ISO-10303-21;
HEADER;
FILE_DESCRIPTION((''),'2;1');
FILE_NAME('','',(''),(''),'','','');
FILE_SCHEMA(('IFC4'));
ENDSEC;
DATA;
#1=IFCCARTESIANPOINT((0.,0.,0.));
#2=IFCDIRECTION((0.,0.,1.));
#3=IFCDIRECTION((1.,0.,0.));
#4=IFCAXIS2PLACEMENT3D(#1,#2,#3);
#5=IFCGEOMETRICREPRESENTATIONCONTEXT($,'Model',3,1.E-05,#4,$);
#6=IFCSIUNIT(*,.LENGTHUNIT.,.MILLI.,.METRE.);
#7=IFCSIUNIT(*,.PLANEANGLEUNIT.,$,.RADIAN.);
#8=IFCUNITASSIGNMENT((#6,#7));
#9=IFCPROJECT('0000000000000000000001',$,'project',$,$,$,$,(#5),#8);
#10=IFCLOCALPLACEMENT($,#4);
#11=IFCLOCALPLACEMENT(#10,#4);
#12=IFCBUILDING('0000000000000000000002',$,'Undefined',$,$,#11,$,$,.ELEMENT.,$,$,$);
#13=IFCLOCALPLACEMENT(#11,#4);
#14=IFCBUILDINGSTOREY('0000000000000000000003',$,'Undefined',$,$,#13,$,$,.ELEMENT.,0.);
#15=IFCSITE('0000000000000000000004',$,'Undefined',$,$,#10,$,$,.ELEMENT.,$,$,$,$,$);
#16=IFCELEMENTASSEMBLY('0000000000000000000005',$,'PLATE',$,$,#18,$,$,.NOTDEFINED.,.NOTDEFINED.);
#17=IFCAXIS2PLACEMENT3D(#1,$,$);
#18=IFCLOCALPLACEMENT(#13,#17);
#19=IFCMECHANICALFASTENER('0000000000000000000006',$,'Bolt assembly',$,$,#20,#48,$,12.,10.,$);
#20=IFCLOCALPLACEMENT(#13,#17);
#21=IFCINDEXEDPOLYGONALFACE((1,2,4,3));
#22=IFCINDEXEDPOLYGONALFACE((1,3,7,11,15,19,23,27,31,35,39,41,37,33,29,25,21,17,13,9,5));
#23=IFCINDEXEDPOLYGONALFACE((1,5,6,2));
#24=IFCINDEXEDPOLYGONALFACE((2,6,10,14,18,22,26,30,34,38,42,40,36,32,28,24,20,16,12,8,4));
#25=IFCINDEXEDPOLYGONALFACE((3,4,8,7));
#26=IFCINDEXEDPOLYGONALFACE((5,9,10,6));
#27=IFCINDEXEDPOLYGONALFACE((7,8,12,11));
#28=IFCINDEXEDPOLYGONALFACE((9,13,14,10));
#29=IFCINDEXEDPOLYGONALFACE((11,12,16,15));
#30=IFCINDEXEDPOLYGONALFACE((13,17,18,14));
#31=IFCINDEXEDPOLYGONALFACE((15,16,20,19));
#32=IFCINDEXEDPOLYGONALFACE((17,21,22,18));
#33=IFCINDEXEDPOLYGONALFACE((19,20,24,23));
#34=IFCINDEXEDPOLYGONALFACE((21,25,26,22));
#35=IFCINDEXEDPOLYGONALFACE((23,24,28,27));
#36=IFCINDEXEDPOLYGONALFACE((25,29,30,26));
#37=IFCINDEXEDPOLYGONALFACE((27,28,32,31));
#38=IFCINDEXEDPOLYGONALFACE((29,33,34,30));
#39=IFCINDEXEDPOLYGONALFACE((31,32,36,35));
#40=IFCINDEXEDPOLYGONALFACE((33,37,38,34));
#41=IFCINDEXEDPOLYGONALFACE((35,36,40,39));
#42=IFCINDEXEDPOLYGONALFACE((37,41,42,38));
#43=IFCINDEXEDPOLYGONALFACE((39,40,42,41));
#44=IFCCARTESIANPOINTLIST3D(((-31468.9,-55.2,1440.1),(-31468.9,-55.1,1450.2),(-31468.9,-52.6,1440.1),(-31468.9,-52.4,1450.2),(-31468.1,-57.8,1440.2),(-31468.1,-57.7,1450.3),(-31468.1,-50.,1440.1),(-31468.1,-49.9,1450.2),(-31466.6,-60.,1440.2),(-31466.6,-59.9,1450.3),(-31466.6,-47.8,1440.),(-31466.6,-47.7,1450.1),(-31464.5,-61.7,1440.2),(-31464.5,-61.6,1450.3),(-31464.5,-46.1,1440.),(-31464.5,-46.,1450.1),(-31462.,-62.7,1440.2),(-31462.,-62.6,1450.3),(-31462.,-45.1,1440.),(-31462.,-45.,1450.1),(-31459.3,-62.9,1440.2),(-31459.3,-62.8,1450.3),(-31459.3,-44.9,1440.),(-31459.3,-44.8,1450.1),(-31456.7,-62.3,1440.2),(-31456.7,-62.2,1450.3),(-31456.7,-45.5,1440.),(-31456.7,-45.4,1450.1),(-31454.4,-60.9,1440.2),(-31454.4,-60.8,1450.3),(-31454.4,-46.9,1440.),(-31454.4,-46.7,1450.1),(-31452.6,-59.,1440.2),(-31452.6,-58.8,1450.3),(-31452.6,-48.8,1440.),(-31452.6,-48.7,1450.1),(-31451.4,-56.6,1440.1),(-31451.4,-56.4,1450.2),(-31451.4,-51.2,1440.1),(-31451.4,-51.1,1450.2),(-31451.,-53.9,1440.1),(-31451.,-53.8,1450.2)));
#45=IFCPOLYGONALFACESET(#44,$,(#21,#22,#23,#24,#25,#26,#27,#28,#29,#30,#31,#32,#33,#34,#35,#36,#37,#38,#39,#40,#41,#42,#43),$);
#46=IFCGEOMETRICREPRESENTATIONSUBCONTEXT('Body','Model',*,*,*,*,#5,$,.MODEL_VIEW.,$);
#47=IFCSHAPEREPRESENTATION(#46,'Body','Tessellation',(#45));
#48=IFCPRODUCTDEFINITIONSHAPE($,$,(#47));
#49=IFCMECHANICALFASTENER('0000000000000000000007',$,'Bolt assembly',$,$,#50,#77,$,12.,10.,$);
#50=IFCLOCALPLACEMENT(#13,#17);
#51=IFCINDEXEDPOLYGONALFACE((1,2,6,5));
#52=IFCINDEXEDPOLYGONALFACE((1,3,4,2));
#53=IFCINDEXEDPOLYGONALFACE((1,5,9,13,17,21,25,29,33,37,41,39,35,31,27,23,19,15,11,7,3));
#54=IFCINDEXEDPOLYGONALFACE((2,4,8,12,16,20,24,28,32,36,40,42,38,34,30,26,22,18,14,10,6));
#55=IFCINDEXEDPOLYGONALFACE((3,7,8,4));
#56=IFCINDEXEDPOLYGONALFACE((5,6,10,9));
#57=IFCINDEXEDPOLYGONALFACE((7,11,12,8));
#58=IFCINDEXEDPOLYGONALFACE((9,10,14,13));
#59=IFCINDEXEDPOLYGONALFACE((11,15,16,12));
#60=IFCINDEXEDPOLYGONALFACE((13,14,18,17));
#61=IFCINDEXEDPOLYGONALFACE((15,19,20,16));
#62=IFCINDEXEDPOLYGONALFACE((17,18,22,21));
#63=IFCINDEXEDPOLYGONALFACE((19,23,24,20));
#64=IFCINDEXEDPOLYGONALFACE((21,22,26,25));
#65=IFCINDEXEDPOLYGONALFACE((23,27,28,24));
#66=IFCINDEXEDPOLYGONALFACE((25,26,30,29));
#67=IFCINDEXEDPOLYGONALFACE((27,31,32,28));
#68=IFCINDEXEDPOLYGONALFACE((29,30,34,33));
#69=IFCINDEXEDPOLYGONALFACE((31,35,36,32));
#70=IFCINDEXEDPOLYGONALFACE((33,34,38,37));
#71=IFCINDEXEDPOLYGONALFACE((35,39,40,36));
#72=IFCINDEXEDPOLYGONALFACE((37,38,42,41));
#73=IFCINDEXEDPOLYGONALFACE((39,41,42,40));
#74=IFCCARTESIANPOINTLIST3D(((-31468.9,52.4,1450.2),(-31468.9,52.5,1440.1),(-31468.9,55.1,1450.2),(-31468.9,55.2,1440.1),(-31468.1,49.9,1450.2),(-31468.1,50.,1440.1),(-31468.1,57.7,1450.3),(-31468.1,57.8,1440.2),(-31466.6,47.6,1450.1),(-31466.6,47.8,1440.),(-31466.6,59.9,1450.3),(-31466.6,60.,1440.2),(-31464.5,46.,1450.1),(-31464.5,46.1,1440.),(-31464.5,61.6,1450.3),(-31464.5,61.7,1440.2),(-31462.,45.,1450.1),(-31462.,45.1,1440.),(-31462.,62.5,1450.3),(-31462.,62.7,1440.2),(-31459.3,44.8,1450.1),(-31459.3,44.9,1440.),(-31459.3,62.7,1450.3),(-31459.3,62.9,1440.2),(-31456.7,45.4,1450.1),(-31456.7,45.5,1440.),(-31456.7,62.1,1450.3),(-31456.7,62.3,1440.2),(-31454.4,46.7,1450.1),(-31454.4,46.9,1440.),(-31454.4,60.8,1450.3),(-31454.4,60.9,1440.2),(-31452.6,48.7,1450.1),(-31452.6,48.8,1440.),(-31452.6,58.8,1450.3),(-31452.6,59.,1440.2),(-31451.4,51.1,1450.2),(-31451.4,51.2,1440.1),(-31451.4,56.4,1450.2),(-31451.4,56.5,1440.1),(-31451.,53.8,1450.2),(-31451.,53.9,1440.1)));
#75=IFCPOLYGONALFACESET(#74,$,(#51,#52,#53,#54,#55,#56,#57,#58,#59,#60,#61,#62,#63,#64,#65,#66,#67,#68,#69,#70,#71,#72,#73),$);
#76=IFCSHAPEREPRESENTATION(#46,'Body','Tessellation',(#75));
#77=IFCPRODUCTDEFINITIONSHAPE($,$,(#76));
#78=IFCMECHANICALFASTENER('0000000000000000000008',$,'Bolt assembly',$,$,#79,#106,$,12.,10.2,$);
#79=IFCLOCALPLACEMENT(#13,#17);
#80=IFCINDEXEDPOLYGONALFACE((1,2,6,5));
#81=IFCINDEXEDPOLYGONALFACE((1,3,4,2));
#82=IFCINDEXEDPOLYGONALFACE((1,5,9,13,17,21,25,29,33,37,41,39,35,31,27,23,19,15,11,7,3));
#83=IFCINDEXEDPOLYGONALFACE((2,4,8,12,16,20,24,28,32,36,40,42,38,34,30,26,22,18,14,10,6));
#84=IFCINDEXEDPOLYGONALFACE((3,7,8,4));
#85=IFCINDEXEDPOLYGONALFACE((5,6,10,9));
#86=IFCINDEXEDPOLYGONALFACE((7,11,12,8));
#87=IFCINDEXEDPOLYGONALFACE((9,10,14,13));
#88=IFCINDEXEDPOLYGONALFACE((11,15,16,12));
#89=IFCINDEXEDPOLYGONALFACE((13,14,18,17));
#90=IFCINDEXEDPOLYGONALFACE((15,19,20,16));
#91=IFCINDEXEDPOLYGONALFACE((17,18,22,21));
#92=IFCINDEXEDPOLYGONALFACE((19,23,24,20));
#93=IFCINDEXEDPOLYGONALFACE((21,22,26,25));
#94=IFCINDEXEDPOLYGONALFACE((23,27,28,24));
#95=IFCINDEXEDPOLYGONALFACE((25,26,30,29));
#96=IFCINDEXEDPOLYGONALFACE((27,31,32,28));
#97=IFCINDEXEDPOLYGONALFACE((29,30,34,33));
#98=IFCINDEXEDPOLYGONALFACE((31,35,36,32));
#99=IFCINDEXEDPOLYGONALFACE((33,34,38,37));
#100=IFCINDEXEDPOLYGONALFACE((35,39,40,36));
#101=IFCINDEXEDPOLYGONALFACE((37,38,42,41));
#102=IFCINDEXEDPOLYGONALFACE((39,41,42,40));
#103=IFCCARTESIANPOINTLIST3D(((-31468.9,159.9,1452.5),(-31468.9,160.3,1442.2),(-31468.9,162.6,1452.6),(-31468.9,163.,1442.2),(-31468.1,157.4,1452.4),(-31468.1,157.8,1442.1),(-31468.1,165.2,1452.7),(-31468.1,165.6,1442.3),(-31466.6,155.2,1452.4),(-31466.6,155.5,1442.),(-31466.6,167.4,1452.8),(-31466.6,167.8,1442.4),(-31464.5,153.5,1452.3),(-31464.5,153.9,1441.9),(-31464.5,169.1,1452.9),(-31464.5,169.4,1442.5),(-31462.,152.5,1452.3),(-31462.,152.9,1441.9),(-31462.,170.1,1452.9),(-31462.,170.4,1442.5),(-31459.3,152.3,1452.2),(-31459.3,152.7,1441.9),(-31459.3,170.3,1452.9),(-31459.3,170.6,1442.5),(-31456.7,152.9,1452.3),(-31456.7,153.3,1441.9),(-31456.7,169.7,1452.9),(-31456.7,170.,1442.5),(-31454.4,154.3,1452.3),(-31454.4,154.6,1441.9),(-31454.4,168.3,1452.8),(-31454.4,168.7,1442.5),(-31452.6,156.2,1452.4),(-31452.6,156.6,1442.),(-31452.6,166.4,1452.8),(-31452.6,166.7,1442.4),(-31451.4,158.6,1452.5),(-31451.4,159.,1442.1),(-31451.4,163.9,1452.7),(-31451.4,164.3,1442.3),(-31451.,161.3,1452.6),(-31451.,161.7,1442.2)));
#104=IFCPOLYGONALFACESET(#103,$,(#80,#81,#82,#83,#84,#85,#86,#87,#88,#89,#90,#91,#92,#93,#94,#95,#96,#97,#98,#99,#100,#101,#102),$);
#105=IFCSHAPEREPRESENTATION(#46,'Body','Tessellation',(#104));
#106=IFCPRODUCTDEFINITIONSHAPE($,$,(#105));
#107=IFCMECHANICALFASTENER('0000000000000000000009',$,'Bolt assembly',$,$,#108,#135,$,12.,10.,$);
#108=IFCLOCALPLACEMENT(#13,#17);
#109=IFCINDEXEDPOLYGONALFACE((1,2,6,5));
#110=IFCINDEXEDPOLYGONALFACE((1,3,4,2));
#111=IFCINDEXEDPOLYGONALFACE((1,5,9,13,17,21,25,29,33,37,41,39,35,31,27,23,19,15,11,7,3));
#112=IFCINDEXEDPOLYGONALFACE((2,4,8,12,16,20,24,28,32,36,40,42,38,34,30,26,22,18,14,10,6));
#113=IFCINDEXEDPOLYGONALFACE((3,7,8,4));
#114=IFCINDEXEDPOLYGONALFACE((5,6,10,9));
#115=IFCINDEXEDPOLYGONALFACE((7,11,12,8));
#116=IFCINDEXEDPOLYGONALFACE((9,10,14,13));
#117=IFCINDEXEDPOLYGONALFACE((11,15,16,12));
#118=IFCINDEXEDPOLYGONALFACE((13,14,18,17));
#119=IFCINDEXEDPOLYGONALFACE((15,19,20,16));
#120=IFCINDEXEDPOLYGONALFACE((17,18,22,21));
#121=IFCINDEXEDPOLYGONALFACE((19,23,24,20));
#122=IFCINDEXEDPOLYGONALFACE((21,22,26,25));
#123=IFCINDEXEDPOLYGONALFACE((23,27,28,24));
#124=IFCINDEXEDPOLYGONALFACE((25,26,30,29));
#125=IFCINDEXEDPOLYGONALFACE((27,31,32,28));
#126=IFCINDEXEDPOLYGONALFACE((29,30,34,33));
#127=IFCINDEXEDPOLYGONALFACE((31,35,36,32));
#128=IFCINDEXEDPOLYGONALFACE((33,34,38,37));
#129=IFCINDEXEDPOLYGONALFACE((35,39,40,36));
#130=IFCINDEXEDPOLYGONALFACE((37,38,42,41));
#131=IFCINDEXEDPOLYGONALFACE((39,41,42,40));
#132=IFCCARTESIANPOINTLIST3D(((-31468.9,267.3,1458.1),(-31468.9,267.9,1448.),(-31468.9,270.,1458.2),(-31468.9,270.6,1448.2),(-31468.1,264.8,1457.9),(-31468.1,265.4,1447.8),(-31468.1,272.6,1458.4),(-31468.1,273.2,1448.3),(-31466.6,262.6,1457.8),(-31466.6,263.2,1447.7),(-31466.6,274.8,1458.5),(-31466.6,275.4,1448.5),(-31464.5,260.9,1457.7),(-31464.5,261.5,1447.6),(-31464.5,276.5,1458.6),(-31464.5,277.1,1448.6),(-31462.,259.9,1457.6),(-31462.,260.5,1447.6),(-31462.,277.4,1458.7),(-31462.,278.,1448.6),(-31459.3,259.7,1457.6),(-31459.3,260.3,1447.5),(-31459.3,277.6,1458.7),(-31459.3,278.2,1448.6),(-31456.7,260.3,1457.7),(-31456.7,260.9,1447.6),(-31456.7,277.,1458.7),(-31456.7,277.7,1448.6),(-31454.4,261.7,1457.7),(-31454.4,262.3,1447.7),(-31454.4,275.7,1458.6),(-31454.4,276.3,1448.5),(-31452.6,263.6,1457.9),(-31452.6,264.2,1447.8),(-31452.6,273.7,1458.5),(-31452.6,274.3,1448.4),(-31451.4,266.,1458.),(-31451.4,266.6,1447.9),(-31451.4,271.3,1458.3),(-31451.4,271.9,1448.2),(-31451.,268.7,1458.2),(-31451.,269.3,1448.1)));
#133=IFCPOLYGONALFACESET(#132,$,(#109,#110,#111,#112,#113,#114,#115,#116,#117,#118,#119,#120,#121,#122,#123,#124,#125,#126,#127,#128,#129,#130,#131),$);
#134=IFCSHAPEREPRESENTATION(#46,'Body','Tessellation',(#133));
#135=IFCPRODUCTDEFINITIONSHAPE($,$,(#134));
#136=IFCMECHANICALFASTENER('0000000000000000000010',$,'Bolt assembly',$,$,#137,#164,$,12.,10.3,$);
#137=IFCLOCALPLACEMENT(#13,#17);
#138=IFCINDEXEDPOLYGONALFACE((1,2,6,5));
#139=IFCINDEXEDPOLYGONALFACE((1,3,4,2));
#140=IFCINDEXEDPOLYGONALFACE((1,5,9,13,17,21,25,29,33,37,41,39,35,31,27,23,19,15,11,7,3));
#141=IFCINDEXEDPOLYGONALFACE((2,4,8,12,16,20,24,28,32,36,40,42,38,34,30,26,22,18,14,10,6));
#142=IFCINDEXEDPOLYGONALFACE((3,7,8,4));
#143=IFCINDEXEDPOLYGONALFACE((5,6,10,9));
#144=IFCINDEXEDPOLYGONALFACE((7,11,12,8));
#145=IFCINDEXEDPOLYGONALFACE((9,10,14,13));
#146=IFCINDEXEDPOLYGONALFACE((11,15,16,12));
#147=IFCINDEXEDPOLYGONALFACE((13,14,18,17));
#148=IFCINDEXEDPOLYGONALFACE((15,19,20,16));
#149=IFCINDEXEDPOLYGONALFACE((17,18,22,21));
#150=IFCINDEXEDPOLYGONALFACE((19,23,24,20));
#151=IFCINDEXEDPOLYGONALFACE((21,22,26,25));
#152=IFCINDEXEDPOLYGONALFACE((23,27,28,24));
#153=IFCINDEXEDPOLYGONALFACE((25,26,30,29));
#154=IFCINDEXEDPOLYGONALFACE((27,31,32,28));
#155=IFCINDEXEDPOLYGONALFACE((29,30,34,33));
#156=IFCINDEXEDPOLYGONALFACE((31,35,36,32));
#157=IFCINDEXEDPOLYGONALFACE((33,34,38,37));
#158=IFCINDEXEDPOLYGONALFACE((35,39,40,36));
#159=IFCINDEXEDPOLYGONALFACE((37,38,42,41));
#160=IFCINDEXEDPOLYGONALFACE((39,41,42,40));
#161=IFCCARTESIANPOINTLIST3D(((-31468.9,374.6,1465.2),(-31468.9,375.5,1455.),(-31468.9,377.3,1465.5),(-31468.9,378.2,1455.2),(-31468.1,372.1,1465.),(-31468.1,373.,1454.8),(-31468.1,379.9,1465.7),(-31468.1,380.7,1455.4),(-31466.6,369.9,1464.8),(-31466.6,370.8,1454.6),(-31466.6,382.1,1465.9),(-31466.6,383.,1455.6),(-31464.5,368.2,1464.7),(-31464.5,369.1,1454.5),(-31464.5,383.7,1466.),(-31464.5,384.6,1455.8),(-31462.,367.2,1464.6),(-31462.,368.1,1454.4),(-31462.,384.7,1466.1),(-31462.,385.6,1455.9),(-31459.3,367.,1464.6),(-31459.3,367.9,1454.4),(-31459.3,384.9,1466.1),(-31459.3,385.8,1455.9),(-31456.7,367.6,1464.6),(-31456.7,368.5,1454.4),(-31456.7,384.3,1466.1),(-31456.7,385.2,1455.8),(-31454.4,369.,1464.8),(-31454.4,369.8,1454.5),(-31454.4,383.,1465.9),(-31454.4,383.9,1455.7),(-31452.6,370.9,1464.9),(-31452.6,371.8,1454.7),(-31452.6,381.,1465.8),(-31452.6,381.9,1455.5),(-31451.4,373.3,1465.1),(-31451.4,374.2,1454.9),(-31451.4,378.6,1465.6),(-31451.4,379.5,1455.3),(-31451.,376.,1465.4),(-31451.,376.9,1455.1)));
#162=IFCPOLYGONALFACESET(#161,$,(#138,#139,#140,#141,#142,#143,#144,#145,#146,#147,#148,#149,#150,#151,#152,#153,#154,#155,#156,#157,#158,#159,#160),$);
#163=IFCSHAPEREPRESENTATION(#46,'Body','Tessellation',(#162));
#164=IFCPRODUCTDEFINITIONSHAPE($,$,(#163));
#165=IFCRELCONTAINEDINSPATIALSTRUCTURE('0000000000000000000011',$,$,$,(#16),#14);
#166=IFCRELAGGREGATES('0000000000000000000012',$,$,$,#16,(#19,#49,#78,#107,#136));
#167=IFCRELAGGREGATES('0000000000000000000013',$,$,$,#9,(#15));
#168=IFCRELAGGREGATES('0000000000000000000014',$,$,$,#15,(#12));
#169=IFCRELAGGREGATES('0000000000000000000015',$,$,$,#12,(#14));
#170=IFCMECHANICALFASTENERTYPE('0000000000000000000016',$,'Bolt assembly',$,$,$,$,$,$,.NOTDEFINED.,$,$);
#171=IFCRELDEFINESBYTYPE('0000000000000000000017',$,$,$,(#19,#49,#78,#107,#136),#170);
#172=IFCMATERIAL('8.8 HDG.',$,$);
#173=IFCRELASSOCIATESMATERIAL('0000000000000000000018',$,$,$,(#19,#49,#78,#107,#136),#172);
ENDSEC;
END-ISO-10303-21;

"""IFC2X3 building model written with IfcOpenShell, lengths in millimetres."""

from ifc_helpers import new_model, si_unit, frame, origin_with_axes, origin_2d_with_axis, place, context, subcontext, project, spatial, circle, extrude, source, transform, mapped, material, type_object, element, aggregate, save


model = new_model("IFC2X3")

# Units and contexts
model_context = context("Model", 3, precision=1e-05, world=origin_with_axes())
body_context = subcontext(model_context, "Body", "Model", "MODEL_VIEW")
ifc_project = project(units=[si_unit("LENGTHUNIT", "METRE", prefix="MILLI"), si_unit("PLANEANGLEUNIT", "RADIAN")], contexts=[model_context])

# Site, building, storey
site_placement = place(None, origin_with_axes())
site = spatial("IfcSite", under=ifc_project, at=site_placement, Name="Undefined", CompositionType="ELEMENT")
building_placement = place(site_placement, origin_with_axes())
building = spatial("IfcBuilding", under=site, at=building_placement, Name="Undefined", CompositionType="ELEMENT")
storey_placement = place(building_placement, origin_with_axes())
storey = spatial("IfcBuildingStorey", under=building, at=storey_placement, Name="Undefined", CompositionType="ELEMENT", Elevation=0.0)

# Element assembly, mechanical fasteners
assembly_placement = place(storey_placement, origin_with_axes())
assembly = element("IfcElementAssembly", 1, at=assembly_placement, inside=storey, Name="PLATE", AssemblyPlace="NOTDEFINED", PredefinedType="NOTDEFINED")
ifc_material_1 = material(Name="8.8 HDG.")
mechanical_fastener_type = type_object("IfcMechanicalFastenerType", Name="Bolt assembly")
shared_shape_1 = source(origin_with_axes(), body_context, "Body", "SweptSolid", [
    extrude(circle(Radius=9.0, at=origin_2d_with_axis()), frame((0.0, 0.7, 0.0), z_axis=(0.0, 1.0, 0.0), x_axis=(1.0, 0.0, 0.0)), (0.0, 0.0, 1.0), 10.1),
])
mechanical_fastener_1_placement = place(assembly_placement, frame((-31460.0, -53.9, 1439.4), z_axis=(0.000001, -0.999927, 0.012083), x_axis=(1.0, 0.000001, -0.000001)))
mechanical_fastener_1 = element("IfcMechanicalFastener", 2, at=mechanical_fastener_1_placement, type_object=mechanical_fastener_type, material=ifc_material_1, Name="Bolt assembly", NominalDiameter=12.0, NominalLength=10.0, context=body_context, shape_type="MappedRepresentation", body=[
    mapped(shared_shape_1, transform((0.0, 0.0, 0.0))),
])
shared_shape_2 = source(origin_with_axes(), body_context, "Body", "SweptSolid", [
    extrude(circle(Radius=9.0, at=origin_2d_with_axis()), frame((0.0, 0.7, 0.0), z_axis=(0.0, 1.0, 0.0), x_axis=(1.0, 0.0, 0.0)), (0.0, 0.0, 1.0), 10.1),
])
mechanical_fastener_2_placement = place(assembly_placement, frame((-31460.0, 53.9, 1439.4), z_axis=(0.000001, -0.999927, -0.012083), x_axis=(1.0, 0.000001, -0.000001)))
mechanical_fastener_2 = element("IfcMechanicalFastener", 3, at=mechanical_fastener_2_placement, type_object=mechanical_fastener_type, material=ifc_material_1, Name="Bolt assembly", NominalDiameter=12.0, NominalLength=10.0, context=body_context, shape_type="MappedRepresentation", body=[
    mapped(shared_shape_2, transform((0.0, 0.0, 0.0))),
])
shared_shape_3 = source(origin_with_axes(), body_context, "Body", "SweptSolid", [
    extrude(circle(Radius=9.0, at=origin_2d_with_axis()), frame((0.0, 0.2, 0.0), z_axis=(0.0, 1.0, 0.0), x_axis=(1.0, 0.0, 0.0)), (0.0, 0.0, 1.0), 10.4),
])
mechanical_fastener_3_placement = place(assembly_placement, frame((-31460.0, 161.7, 1442.0), z_axis=(0.000001, -0.999343, -0.036241), x_axis=(1.0, 0.000001, -0.000001)))
mechanical_fastener_3 = element("IfcMechanicalFastener", 4, at=mechanical_fastener_3_placement, type_object=mechanical_fastener_type, material=ifc_material_1, Name="Bolt assembly", NominalDiameter=12.0, NominalLength=10.2, context=body_context, shape_type="MappedRepresentation", body=[
    mapped(shared_shape_3, transform((0.0, 0.0, 0.0))),
])
shared_shape_4 = source(origin_with_axes(), body_context, "Body", "SweptSolid", [
    extrude(circle(Radius=9.0, at=origin_2d_with_axis()), frame((0.0, 0.9, 0.0), z_axis=(0.0, 1.0, 0.0), x_axis=(1.0, 0.0, 0.0)), (0.0, 0.0, 1.0), 10.1),
])
mechanical_fastener_4_placement = place(assembly_placement, frame((-31460.0, 269.3, 1447.2), z_axis=(0.000001, -0.998176, -0.060379), x_axis=(1.0, 0.000001, -0.000001)))
mechanical_fastener_4 = element("IfcMechanicalFastener", 5, at=mechanical_fastener_4_placement, type_object=mechanical_fastener_type, material=ifc_material_1, Name="Bolt assembly", NominalDiameter=12.0, NominalLength=10.0, context=body_context, shape_type="MappedRepresentation", body=[
    mapped(shared_shape_4, transform((0.0, 0.0, 0.0))),
])
shared_shape_5 = source(origin_with_axes(), body_context, "Body", "SweptSolid", [
    extrude(circle(Radius=9.0, at=origin_2d_with_axis()), frame((0.0, 0.1, 0.0), z_axis=(0.0, 1.0, 0.0), x_axis=(1.0, 0.0, 0.0)), (0.0, 0.0, 1.0), 10.3),
])
mechanical_fastener_5_placement = place(assembly_placement, frame((-31460.0, 376.9, 1455.0), z_axis=(0.000001, -0.996425, -0.084481), x_axis=(1.0, 0.000001, -0.000001)))
mechanical_fastener_5 = element("IfcMechanicalFastener", 6, at=mechanical_fastener_5_placement, type_object=mechanical_fastener_type, material=ifc_material_1, Name="Bolt assembly", NominalDiameter=12.0, NominalLength=10.3, context=body_context, shape_type="MappedRepresentation", body=[
    mapped(shared_shape_5, transform((0.0, 0.0, 0.0))),
])
aggregate(assembly, [mechanical_fastener_1, mechanical_fastener_2, mechanical_fastener_3, mechanical_fastener_4, mechanical_fastener_5])

save(model, "model.ifc")
